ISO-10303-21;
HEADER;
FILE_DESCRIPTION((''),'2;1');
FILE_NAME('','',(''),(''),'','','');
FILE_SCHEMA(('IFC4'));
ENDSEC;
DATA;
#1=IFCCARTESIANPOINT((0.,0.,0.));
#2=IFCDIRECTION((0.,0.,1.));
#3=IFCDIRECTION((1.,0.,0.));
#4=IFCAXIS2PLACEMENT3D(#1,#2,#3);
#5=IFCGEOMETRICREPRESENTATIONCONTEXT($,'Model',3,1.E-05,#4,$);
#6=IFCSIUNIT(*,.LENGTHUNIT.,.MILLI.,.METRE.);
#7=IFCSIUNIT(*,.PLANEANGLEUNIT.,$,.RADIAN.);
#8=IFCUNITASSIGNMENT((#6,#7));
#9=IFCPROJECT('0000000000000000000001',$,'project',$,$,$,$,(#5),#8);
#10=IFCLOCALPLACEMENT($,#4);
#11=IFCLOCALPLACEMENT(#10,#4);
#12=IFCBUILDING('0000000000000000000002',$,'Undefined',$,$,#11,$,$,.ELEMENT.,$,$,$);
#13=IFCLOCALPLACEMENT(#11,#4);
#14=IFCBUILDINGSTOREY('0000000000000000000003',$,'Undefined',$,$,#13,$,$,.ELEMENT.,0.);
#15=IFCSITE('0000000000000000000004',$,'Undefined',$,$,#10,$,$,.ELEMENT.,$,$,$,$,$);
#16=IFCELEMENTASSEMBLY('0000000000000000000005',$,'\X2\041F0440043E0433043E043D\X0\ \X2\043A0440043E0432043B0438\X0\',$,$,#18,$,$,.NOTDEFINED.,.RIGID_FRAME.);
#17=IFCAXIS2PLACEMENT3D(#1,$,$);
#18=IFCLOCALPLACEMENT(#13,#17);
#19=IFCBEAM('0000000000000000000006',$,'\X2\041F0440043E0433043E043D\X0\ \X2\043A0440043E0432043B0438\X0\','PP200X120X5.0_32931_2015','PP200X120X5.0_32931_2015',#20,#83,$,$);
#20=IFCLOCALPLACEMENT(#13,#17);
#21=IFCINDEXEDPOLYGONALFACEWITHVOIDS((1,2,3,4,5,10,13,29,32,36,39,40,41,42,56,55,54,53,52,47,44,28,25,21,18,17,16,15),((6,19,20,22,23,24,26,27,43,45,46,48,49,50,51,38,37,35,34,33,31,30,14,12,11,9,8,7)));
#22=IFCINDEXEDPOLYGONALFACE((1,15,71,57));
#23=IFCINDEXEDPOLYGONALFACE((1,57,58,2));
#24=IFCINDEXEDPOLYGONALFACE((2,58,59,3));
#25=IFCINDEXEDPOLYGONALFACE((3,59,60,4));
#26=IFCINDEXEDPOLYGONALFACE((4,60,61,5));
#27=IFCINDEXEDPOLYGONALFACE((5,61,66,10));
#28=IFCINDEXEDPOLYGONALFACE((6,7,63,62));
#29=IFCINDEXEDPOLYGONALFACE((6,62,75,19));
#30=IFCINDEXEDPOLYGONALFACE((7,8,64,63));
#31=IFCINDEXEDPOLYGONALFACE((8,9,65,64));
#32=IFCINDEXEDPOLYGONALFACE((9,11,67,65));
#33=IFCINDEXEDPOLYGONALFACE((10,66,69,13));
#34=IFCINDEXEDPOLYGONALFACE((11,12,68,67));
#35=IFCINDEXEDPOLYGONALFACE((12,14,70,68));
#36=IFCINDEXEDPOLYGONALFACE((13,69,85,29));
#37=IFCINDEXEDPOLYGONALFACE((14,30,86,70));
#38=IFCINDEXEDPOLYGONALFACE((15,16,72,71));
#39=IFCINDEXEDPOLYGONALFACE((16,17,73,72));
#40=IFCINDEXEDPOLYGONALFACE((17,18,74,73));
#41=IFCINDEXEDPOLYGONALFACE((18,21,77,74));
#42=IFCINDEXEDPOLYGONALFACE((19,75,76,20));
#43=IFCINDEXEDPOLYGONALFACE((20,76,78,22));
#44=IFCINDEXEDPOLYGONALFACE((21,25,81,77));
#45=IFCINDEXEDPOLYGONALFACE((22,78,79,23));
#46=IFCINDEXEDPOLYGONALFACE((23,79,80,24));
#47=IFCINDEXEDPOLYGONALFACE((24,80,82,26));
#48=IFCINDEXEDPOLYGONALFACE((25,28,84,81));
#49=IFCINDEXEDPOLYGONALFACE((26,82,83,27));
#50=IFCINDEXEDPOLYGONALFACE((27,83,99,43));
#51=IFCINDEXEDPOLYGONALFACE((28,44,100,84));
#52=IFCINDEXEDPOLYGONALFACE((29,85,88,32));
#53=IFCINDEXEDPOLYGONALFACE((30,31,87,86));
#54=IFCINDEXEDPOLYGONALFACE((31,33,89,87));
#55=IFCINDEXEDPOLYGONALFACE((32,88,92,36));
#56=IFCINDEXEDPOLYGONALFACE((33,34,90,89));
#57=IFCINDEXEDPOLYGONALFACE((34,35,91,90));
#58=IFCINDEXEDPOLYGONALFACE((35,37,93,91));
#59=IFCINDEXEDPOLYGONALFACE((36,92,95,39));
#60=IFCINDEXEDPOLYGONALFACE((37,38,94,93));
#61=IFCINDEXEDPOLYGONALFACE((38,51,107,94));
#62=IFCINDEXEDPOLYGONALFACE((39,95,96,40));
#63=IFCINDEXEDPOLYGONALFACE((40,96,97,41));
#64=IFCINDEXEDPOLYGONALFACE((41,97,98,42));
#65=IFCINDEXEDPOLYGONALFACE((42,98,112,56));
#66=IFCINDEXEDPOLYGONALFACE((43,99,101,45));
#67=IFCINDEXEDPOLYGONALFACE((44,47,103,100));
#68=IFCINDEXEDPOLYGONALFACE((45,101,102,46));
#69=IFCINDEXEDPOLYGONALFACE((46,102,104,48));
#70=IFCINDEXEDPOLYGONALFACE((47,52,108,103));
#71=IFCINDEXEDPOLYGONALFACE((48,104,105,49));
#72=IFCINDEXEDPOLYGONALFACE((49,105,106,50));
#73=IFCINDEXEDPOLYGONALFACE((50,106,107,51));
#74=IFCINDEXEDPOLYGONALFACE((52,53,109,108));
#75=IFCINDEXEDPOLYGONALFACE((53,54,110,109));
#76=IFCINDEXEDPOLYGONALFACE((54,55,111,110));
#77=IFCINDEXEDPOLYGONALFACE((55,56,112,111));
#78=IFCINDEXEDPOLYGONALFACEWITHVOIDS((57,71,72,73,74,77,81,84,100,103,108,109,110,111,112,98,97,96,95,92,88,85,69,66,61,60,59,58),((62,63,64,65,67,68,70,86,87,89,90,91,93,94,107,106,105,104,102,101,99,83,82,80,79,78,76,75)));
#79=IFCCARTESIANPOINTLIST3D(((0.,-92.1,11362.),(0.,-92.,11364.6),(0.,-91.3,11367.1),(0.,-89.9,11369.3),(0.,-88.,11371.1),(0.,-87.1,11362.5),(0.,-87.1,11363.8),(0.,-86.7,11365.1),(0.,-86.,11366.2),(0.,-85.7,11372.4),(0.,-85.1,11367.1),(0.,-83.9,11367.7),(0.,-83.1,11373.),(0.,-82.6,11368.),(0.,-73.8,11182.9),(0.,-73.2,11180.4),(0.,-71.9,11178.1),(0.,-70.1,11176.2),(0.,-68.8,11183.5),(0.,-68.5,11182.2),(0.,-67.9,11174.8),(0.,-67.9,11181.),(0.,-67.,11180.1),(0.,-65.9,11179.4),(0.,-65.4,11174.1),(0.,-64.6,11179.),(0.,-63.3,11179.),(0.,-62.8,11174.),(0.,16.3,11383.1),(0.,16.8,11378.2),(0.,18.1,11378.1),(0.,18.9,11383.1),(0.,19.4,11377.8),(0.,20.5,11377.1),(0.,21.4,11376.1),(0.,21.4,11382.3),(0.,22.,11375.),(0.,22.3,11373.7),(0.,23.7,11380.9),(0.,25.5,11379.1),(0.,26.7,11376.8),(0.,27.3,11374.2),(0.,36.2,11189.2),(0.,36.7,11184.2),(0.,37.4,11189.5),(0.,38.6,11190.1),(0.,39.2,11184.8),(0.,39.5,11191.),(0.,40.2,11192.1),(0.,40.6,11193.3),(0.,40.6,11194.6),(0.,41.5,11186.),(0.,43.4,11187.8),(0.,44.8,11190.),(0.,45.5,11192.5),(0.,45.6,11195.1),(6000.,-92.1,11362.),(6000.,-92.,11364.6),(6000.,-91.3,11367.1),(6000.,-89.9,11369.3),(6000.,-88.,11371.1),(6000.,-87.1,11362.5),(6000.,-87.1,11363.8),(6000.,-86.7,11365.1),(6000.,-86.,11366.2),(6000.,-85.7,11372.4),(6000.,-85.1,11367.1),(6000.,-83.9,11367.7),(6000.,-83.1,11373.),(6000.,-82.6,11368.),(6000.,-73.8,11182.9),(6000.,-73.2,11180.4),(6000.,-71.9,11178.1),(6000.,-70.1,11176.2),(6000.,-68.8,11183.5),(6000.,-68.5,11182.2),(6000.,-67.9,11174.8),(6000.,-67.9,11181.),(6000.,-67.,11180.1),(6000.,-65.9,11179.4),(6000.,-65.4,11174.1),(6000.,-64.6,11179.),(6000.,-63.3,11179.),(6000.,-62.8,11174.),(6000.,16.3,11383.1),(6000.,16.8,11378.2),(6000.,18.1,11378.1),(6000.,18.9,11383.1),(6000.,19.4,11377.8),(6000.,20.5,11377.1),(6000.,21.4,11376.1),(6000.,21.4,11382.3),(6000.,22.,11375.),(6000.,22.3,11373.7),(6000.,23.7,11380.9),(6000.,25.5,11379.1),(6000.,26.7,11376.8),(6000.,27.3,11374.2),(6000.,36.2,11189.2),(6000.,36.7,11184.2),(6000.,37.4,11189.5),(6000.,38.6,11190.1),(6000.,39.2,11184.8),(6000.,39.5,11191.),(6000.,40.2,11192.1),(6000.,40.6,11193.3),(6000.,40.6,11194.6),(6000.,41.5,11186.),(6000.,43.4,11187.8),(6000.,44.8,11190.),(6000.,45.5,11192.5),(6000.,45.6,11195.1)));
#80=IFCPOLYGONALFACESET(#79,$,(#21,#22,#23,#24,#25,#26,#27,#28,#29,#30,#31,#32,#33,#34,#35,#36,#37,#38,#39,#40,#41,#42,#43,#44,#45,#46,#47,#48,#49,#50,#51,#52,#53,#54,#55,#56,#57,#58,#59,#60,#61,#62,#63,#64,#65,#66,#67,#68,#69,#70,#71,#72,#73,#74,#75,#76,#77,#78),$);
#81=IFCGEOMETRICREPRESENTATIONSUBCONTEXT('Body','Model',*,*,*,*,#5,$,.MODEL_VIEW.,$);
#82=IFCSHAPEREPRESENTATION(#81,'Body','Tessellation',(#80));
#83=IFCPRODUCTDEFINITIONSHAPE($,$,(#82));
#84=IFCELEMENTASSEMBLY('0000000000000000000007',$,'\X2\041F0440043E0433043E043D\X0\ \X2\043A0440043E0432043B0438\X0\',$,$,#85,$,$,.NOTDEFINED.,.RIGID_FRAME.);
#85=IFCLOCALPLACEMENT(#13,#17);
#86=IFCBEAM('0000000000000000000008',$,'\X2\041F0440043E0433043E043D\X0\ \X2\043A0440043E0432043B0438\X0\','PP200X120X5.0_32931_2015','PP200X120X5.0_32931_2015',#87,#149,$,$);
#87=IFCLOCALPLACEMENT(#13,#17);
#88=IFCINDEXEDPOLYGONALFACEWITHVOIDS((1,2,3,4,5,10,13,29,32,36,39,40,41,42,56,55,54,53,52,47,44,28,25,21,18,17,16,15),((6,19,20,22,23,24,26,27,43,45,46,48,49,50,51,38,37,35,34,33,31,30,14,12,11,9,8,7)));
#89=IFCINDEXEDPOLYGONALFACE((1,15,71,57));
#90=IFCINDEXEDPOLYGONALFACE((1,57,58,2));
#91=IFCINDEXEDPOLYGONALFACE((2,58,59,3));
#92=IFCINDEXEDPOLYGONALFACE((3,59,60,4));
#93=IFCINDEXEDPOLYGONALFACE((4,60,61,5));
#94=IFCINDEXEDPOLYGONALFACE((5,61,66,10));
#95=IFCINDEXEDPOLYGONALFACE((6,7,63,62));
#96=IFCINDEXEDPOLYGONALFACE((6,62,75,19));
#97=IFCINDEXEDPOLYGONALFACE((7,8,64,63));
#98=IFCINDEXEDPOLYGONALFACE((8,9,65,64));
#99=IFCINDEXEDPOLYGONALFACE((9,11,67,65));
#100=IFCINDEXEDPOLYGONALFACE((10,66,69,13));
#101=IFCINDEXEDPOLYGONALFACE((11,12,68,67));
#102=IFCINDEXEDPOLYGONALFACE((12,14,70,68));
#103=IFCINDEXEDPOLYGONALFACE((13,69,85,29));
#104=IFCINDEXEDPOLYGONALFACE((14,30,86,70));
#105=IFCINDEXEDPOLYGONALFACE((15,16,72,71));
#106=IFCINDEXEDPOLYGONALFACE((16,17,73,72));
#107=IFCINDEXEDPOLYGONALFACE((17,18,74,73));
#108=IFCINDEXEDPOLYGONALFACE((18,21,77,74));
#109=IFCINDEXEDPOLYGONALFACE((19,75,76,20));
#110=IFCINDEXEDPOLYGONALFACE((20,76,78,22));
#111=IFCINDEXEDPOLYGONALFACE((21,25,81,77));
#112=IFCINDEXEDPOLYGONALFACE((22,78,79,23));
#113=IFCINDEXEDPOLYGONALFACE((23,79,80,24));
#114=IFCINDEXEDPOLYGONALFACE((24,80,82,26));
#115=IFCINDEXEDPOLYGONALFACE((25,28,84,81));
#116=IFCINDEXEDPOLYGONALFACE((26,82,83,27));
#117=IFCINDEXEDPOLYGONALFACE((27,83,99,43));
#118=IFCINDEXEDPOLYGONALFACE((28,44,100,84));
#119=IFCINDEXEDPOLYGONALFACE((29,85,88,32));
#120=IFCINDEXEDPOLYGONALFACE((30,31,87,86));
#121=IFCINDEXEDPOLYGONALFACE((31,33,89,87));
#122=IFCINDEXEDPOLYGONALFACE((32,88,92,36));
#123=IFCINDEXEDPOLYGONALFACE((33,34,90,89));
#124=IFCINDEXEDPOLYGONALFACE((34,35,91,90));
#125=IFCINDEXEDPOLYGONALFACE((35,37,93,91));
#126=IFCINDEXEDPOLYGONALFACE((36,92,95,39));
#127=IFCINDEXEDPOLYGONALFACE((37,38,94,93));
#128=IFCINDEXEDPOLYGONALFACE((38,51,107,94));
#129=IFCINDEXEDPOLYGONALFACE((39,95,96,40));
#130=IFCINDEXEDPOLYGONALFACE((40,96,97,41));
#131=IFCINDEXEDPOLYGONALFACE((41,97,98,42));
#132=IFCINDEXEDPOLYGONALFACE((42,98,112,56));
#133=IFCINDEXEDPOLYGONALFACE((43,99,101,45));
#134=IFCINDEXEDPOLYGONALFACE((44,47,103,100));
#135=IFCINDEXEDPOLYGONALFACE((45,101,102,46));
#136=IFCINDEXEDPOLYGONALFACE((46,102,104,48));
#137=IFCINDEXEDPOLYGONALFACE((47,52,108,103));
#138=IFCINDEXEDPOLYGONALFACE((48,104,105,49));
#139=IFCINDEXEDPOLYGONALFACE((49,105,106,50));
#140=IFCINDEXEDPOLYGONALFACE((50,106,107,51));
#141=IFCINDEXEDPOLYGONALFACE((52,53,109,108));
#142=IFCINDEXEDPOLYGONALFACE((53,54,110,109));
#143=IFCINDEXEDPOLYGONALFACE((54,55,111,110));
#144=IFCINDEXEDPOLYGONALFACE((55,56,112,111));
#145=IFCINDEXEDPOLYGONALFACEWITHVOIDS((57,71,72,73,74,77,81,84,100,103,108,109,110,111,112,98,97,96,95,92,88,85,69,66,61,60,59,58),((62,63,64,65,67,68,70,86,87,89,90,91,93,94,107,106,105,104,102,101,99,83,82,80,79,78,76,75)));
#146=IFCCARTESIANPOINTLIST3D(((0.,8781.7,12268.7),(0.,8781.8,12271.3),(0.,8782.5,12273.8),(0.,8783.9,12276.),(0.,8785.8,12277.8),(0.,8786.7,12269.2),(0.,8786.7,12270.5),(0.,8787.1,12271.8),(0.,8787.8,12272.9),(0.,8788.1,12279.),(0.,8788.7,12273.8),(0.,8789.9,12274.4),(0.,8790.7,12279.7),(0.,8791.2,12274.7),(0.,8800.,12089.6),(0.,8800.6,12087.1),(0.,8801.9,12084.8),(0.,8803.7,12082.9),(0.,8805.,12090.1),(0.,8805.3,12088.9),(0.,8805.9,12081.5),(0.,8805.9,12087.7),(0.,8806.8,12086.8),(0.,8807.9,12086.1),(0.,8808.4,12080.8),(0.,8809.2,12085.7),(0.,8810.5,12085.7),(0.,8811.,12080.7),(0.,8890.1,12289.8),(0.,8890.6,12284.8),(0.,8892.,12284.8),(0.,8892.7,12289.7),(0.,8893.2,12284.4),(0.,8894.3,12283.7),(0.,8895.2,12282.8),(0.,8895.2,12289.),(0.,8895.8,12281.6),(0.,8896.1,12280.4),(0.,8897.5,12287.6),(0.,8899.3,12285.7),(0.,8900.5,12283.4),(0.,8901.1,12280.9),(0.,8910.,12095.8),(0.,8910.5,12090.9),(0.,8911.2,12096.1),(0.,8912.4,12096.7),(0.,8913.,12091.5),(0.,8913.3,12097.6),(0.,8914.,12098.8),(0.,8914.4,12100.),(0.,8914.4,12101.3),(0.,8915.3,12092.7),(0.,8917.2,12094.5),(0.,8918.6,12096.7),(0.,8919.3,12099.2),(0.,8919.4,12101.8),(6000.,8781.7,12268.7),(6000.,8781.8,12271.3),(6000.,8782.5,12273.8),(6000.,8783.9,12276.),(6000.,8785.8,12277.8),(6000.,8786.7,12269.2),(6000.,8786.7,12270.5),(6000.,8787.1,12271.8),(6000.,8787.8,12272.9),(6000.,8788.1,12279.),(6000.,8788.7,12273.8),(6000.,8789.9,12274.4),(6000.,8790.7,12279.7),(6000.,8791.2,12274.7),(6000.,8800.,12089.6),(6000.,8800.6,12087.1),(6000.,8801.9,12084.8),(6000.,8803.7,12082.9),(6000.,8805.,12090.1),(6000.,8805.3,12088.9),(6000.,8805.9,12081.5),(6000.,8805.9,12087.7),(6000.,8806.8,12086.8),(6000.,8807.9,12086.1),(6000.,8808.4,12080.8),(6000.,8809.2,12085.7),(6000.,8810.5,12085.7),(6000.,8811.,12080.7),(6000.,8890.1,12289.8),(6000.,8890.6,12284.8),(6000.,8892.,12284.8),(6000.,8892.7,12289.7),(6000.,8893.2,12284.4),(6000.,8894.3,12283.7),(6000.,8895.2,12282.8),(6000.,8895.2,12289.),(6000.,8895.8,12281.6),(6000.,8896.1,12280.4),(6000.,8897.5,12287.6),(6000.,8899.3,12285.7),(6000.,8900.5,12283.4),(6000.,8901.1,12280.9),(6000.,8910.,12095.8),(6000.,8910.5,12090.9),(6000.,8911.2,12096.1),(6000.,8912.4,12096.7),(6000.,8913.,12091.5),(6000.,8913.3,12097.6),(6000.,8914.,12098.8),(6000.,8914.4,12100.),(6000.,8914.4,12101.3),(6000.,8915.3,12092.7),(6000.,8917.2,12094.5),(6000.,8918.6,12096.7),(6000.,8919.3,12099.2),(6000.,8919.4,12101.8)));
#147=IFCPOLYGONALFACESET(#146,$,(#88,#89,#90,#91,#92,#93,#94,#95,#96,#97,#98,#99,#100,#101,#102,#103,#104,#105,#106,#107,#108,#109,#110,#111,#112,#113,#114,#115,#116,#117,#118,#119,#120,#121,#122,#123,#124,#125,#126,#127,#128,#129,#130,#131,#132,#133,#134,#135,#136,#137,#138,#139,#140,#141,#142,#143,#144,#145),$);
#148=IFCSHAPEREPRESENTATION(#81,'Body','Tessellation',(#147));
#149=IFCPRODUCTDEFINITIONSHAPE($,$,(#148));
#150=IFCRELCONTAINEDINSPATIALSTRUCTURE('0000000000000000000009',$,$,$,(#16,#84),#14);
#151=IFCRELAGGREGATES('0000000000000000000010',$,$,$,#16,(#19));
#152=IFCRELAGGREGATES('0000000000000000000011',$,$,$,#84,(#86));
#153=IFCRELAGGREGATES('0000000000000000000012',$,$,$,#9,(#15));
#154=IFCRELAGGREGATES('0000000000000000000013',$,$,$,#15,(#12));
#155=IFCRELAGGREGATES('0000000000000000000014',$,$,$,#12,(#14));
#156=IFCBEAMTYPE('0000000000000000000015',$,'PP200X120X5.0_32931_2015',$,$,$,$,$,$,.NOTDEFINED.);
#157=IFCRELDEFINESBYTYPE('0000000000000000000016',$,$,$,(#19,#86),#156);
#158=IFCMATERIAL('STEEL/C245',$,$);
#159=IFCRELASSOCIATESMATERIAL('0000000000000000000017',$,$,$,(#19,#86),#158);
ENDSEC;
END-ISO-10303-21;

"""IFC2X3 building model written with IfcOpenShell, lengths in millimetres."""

from ifc_helpers import new_model, si_unit, frame, origin_with_axes, origin_2d_with_axis, place, context, subcontext, project, spatial, hollow_rectangle, extrude, material, type_object, element, aggregate, save


model = new_model("IFC2X3")

# Units and contexts
model_context = context("Model", 3, precision=1e-05, world=origin_with_axes())
body_context = subcontext(model_context, "Body", "Model", "MODEL_VIEW")
ifc_project = project(units=[si_unit("LENGTHUNIT", "METRE", prefix="MILLI"), si_unit("PLANEANGLEUNIT", "RADIAN")], contexts=[model_context])

# Site, building, storey
site_placement = place(None, origin_with_axes())
site = spatial("IfcSite", under=ifc_project, at=site_placement, Name="Undefined", CompositionType="ELEMENT")
building_placement = place(site_placement, origin_with_axes())
building = spatial("IfcBuilding", under=site, at=building_placement, Name="Undefined", CompositionType="ELEMENT")
storey_placement = place(building_placement, origin_with_axes())
storey = spatial("IfcBuildingStorey", under=building, at=storey_placement, Name="Undefined", CompositionType="ELEMENT", Elevation=0.0)

# Element assemblies, beams
ifc_material_1 = material(Name="STEEL/C245")
beam_type_1 = type_object("IfcBeamType", Name="PP200X120X5.0_32931_2015", PredefinedType="NOTDEFINED")
assembly_1_placement = place(storey_placement, origin_with_axes())
assembly_1 = element("IfcElementAssembly", 1, at=assembly_1_placement, inside=storey, Name="Прогон кровли", AssemblyPlace="NOTDEFINED", PredefinedType="RIGID_FRAME")
beam_1_placement = place(assembly_1_placement, frame((6000.0, -23.2, 11278.6), z_axis=(0.0, -0.101645, 0.994821), x_axis=(-1.0, 0.0, 0.0)))
beam_1 = element("IfcBeam", 2, at=beam_1_placement, type_object=beam_type_1, material=ifc_material_1, Name="Прогон кровли", Description="PP200X120X5.0_32931_2015", ObjectType="PP200X120X5.0_32931_2015", context=body_context, shape_type="SweptSolid", body=[
    extrude(hollow_rectangle(XDim=120.0, YDim=200.0, WallThickness=5.0, InnerFilletRadius=5.0, OuterFilletRadius=10.0, at=origin_2d_with_axis()), frame((6000.0, 0.0, 0.0), z_axis=(-1.0, 0.0, 0.0), x_axis=(0.0, -1.0, 0.0)), (0.0, 0.0, 1.0), 6000.0),
])
aggregate(assembly_1, [beam_1])
assembly_2_placement = place(storey_placement, origin_with_axes())
assembly_2 = element("IfcElementAssembly", 3, at=assembly_2_placement, inside=storey, Name="Прогон кровли", AssemblyPlace="NOTDEFINED", PredefinedType="RIGID_FRAME")
beam_2_placement = place(assembly_2_placement, frame((6000.0, 8850.6, 12185.3), z_axis=(0.0, -0.101645, 0.994821), x_axis=(-1.0, 0.0, 0.0)))
beam_2 = element("IfcBeam", 4, at=beam_2_placement, type_object=beam_type_1, material=ifc_material_1, Name="Прогон кровли", Description="PP200X120X5.0_32931_2015", ObjectType="PP200X120X5.0_32931_2015", context=body_context, shape_type="SweptSolid", body=[
    extrude(hollow_rectangle(XDim=120.0, YDim=200.0, WallThickness=5.0, InnerFilletRadius=5.0, OuterFilletRadius=10.0, at=origin_2d_with_axis()), frame((6000.0, 0.0, 0.0), z_axis=(-1.0, 0.0, 0.0), x_axis=(0.0, -1.0, 0.0)), (0.0, 0.0, 1.0), 6000.0),
])
aggregate(assembly_2, [beam_2])

save(model, "model.ifc")
